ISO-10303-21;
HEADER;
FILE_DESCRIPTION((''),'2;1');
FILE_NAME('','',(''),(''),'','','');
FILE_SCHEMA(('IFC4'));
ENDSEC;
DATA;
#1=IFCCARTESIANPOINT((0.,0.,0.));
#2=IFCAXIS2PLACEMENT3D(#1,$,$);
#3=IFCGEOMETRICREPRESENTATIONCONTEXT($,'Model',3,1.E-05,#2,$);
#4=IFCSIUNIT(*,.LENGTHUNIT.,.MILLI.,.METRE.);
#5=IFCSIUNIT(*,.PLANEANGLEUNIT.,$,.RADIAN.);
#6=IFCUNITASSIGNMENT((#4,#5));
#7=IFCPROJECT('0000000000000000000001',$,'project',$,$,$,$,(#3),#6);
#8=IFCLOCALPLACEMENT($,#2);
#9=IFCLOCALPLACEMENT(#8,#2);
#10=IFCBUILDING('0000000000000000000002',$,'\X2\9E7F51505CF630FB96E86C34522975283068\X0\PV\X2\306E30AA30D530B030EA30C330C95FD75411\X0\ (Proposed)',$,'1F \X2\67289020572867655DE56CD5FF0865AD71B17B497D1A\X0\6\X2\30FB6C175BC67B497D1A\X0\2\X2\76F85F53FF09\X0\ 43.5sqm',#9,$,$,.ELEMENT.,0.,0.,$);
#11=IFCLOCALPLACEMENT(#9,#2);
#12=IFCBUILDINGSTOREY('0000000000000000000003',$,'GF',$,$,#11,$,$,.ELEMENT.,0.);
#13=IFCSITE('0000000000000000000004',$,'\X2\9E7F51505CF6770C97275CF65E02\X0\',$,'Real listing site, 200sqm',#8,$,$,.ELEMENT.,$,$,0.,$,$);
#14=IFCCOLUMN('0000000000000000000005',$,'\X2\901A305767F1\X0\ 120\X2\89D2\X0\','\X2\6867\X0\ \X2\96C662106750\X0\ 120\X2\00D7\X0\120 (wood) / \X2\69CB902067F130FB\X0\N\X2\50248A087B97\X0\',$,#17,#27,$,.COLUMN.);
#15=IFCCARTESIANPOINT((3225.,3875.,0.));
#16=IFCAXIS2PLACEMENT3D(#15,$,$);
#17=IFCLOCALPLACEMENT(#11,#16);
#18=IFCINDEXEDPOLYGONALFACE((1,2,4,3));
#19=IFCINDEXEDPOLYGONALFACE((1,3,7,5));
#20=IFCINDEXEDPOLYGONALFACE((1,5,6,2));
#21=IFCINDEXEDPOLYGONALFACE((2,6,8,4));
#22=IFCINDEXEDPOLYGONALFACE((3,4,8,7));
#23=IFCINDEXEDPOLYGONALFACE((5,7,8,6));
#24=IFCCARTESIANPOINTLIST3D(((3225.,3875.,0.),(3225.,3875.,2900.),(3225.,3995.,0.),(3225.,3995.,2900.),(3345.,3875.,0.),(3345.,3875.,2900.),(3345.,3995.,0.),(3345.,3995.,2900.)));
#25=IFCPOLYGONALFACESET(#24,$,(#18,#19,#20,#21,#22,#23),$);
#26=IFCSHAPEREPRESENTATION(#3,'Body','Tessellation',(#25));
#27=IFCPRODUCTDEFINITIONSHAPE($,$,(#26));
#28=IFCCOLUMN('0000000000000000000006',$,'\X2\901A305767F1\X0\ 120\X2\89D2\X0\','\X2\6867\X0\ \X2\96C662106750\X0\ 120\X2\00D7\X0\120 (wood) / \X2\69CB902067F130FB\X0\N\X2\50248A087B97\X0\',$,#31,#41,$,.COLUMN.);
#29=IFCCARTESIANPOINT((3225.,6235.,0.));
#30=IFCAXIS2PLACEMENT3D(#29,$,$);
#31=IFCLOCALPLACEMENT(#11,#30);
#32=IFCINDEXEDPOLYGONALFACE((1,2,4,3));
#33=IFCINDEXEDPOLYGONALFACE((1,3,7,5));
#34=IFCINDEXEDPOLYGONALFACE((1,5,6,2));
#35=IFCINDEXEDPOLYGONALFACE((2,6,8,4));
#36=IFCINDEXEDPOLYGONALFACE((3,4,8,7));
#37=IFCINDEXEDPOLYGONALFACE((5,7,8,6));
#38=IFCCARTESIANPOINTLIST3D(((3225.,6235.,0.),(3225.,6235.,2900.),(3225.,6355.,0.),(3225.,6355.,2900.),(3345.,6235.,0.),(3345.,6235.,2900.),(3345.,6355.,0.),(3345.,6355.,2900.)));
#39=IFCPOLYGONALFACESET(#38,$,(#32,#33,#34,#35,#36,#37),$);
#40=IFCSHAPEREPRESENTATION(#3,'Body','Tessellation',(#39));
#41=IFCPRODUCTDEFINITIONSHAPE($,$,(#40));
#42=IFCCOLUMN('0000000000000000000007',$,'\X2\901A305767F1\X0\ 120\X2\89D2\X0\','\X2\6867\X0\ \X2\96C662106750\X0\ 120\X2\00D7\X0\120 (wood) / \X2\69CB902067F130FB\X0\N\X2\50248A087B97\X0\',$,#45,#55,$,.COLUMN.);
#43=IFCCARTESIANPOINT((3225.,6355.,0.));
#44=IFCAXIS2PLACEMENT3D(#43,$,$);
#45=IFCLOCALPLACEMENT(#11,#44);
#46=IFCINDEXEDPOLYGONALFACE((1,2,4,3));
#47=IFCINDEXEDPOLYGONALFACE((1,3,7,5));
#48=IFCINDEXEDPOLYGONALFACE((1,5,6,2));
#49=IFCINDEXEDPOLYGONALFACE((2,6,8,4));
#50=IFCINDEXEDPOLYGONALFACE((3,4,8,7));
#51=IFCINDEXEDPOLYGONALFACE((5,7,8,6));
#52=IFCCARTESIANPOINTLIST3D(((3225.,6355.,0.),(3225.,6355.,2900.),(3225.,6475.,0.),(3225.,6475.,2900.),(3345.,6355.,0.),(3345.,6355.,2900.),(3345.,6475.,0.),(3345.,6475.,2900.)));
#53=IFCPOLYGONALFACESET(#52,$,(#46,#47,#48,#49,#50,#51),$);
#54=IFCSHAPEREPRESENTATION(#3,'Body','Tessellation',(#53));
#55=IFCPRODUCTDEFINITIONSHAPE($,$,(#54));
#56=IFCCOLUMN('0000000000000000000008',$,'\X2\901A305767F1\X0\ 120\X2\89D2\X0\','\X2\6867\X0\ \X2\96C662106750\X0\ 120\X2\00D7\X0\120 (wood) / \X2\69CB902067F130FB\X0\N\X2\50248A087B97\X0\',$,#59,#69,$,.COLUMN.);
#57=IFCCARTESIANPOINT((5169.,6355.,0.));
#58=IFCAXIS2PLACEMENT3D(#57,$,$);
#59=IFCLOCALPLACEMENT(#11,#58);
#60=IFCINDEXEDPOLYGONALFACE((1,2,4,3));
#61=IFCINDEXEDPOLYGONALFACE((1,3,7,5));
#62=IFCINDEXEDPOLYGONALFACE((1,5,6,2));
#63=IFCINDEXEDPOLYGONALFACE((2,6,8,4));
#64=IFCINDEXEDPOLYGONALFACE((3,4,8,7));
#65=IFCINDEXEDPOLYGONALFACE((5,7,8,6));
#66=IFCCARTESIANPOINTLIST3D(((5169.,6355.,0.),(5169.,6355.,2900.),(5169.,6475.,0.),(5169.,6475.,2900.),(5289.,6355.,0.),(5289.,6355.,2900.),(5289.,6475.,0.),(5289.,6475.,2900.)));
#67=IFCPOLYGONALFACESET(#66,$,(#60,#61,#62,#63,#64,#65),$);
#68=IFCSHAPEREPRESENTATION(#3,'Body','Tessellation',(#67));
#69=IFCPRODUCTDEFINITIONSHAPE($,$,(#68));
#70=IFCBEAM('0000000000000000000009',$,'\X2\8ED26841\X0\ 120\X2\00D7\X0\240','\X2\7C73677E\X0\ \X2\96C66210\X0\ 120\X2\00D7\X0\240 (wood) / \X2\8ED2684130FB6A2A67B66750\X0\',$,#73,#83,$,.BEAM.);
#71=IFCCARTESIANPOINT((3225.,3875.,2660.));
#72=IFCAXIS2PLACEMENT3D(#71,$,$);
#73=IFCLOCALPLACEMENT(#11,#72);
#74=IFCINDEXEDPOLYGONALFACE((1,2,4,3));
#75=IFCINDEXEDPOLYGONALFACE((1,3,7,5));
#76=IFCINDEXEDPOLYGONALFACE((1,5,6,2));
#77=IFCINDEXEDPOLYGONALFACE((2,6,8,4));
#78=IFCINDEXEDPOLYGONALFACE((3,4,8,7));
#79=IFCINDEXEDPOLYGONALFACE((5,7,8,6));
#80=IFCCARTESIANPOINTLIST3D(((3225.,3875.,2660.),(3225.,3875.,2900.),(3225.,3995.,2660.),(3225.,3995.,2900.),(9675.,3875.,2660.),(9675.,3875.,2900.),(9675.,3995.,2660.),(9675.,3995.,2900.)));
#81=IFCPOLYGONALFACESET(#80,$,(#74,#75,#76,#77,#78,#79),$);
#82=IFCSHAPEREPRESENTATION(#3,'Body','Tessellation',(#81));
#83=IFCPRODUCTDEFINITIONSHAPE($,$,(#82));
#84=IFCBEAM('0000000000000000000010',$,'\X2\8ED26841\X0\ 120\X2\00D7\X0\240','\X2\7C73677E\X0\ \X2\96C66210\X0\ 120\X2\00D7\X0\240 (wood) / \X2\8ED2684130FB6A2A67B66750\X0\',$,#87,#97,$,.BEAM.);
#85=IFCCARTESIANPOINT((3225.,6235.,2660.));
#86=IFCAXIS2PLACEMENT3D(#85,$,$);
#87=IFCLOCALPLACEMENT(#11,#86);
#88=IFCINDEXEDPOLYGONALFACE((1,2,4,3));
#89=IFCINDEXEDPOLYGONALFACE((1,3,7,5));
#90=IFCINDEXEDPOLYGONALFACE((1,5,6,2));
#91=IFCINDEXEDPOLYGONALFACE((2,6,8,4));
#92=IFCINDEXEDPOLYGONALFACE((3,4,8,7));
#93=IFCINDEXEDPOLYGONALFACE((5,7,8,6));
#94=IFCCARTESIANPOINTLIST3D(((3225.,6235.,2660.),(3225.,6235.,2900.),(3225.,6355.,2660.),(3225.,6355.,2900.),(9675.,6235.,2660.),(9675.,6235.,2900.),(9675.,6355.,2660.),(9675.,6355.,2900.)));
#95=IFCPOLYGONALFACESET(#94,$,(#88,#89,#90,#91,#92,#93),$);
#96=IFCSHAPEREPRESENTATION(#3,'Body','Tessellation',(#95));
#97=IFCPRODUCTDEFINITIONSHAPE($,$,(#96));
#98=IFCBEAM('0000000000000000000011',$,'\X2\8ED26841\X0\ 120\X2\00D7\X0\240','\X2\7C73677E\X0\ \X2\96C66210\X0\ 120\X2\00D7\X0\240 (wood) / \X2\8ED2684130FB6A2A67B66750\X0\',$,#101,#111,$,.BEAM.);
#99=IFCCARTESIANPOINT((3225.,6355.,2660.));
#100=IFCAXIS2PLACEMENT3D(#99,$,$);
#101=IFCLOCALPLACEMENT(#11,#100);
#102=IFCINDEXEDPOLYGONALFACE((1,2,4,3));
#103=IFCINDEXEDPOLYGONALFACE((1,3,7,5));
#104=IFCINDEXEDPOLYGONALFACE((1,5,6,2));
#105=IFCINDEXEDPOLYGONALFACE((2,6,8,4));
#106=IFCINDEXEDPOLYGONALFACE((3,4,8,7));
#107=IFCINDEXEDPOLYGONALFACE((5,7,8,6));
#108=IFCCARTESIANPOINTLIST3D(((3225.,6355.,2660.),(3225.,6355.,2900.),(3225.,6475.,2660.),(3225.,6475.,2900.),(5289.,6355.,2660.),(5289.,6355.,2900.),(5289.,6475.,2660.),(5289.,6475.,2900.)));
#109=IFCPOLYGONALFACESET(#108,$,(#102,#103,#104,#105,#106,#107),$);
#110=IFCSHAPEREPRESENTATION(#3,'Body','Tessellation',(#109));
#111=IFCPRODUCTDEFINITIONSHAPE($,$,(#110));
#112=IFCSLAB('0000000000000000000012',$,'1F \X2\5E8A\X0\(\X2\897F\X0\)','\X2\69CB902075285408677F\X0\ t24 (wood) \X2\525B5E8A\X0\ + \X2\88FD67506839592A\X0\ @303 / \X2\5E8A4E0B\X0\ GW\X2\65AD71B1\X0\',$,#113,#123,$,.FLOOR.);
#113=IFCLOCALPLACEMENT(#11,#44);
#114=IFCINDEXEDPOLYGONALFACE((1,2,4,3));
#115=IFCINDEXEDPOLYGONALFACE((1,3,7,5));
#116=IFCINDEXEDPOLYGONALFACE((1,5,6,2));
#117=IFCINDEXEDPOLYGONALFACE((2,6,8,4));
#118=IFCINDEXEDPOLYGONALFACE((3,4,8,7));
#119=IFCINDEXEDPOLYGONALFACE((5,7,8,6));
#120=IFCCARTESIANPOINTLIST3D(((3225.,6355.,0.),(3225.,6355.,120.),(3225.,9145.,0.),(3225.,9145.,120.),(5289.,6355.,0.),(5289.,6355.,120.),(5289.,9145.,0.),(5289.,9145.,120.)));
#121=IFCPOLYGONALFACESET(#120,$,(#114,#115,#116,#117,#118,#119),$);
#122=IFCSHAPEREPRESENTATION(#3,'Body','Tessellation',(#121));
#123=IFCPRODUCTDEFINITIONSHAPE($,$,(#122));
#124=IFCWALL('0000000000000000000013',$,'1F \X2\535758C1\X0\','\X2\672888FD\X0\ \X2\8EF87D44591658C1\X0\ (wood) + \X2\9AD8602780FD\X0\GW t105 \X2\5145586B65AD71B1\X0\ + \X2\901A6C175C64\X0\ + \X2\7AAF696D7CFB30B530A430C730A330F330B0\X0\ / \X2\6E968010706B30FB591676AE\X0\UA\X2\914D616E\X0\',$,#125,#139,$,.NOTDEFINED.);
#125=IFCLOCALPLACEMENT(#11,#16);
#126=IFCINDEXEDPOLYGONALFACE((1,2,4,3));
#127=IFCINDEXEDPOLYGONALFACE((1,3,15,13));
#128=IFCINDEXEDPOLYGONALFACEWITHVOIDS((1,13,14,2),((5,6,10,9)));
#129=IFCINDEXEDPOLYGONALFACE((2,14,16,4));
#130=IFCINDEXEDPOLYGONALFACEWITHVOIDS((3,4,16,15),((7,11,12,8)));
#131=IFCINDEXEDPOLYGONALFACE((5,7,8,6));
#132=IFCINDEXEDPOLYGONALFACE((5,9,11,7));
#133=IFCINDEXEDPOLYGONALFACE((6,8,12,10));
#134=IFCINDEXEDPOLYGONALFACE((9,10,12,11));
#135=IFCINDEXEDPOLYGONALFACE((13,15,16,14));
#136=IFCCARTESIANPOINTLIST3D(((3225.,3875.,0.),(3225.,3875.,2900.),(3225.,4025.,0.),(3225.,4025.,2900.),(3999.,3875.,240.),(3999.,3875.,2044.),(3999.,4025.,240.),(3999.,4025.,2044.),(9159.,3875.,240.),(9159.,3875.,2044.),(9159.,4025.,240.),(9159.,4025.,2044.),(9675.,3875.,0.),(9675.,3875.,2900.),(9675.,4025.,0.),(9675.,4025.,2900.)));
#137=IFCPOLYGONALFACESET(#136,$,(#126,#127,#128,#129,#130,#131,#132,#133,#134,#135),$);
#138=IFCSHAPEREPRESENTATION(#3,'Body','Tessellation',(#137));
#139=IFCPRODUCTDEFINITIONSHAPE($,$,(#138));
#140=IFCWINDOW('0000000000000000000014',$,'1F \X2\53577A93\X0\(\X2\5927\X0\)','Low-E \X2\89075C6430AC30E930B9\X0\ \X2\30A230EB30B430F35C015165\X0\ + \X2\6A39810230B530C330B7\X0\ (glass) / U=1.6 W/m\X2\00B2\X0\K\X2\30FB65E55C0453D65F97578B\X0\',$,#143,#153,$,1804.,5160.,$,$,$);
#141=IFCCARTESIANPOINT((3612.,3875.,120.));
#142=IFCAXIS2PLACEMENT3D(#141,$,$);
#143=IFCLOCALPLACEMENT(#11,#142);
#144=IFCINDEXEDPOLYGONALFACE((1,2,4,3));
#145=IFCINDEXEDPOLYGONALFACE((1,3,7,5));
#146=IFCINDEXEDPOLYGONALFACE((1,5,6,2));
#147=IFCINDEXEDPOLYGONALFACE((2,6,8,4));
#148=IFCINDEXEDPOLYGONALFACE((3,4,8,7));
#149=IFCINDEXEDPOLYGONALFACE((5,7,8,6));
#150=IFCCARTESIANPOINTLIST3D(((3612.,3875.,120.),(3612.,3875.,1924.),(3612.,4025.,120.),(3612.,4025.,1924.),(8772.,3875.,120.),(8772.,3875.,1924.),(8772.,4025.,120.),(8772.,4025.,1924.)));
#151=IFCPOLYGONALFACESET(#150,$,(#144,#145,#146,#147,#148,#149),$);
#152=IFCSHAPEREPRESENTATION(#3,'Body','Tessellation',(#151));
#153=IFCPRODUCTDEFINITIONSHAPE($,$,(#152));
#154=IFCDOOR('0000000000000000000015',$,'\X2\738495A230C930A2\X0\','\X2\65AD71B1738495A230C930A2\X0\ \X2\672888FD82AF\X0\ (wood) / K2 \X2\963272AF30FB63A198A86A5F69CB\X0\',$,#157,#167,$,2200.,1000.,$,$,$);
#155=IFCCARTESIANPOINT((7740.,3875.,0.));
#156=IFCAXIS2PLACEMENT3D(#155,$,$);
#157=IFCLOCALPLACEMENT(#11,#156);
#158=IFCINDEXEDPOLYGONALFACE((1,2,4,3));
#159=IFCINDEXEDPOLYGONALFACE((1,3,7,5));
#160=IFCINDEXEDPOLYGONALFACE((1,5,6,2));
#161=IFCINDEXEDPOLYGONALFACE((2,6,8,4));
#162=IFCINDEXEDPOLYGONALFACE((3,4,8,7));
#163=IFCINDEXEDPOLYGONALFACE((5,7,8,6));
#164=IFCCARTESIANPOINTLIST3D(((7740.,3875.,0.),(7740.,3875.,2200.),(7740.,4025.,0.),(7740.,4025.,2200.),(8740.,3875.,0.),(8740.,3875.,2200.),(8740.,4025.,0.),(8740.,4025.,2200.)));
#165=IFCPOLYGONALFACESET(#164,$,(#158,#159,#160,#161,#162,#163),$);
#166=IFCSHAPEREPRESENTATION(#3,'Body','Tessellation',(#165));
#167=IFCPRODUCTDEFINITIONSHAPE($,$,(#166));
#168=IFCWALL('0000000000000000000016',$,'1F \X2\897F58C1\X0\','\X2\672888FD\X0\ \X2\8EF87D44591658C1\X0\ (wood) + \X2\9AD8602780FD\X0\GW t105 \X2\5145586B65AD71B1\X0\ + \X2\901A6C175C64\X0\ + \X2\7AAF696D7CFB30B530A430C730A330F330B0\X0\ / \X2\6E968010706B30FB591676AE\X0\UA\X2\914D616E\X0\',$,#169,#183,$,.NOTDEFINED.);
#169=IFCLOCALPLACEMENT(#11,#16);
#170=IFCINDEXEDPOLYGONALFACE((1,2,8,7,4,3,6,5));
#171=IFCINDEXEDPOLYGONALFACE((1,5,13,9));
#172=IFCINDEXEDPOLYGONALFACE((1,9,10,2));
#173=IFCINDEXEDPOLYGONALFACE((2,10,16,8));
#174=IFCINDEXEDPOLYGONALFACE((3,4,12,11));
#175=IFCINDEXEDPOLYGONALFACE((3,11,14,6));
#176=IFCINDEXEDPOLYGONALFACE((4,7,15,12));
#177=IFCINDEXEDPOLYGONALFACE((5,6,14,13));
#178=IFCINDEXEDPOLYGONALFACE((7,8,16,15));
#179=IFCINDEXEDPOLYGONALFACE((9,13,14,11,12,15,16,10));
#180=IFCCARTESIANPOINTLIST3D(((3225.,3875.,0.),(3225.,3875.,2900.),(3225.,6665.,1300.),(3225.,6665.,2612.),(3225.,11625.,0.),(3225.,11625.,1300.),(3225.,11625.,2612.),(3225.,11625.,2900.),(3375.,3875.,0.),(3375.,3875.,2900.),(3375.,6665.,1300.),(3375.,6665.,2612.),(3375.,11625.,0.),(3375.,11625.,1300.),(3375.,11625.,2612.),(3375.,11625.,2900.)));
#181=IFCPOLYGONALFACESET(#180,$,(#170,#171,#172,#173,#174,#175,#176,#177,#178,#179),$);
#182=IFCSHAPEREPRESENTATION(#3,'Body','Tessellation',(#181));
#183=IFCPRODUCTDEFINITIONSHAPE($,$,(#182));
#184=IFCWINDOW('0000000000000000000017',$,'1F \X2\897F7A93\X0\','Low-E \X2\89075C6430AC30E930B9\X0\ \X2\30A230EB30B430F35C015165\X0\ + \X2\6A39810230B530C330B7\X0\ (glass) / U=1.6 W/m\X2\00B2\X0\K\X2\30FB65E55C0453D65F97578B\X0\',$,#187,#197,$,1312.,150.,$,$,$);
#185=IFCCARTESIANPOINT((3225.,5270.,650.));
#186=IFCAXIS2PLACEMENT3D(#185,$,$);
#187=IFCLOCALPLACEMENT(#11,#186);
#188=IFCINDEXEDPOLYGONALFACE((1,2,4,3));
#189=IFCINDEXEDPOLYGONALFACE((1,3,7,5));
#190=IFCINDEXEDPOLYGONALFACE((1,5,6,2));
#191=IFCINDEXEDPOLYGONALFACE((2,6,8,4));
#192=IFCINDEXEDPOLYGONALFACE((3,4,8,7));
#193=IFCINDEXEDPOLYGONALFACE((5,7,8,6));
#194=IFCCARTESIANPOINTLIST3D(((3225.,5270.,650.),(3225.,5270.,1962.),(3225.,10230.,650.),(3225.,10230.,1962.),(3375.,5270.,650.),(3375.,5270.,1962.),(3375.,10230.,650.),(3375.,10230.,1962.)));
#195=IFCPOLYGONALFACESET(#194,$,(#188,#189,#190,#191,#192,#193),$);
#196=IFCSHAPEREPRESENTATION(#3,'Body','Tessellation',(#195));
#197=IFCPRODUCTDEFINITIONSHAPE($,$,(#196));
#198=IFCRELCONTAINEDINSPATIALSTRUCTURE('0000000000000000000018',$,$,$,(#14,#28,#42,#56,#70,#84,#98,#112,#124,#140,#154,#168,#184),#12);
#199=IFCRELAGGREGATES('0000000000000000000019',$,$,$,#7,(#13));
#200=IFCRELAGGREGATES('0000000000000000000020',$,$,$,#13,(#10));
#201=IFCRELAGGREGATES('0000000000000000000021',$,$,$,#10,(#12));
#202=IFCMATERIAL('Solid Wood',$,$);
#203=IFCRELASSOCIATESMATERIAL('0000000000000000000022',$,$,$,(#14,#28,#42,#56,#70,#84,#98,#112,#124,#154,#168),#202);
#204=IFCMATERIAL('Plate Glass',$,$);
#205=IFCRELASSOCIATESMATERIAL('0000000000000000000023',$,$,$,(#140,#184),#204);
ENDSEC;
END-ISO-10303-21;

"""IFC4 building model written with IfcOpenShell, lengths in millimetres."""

from ifc_helpers import new_model, si_unit, frame, frame_2d, origin, place, context, project, spatial, rectangle, extrude, material, element, fill, save


model = new_model("IFC4")

# Units and contexts
model_context = context("Model", 3, precision=1e-05, world=origin())
ifc_project = project(units=[si_unit("LENGTHUNIT", "METRE", prefix="MILLI"), si_unit("PLANEANGLEUNIT", "RADIAN")], contexts=[model_context])

# Site, building, storey
site_placement = place(None, origin())
site = spatial("IfcSite", under=ifc_project, at=site_placement, Name="鹿児島県霧島市", ObjectType="Real listing site, 200sqm", CompositionType="ELEMENT", RefElevation=0.0)
building_placement = place(site_placement, origin())
building = spatial("IfcBuilding", under=site, at=building_placement, Name="鹿児島・雨水利用とPVのオフグリッド志向 (Proposed)", ObjectType="1F 木造在来工法（断熱等級6・気密等級2相当） 43.5sqm", CompositionType="ELEMENT", ElevationOfRefHeight=0.0, ElevationOfTerrain=0.0)
storey_placement = place(building_placement, origin())
storey = spatial("IfcBuildingStorey", under=building, at=storey_placement, Name="GF", CompositionType="ELEMENT", Elevation=0.0)

# Columns
ifc_material_1 = material(Name="Solid Wood")
column_1_placement = place(storey_placement, frame((3225.0, 3875.0, 0.0)))
element("IfcColumn", 1, at=column_1_placement, inside=storey, material=ifc_material_1, Name="通し柱 120角", Description="桧 集成材 120×120 (wood) / 構造柱・N値計算", PredefinedType="COLUMN", context=model_context, shape_type="SweptSolid", body=[
    extrude(rectangle(XDim=120.0, YDim=120.0, at=frame_2d((60.0, 60.0))), frame((3225.0, 3875.0, 0.0)), (0.0, 0.0, 1.0), 2900.0),
])
column_2_placement = place(storey_placement, frame((3225.0, 6235.0, 0.0)))
element("IfcColumn", 2, at=column_2_placement, inside=storey, material=ifc_material_1, Name="通し柱 120角", Description="桧 集成材 120×120 (wood) / 構造柱・N値計算", PredefinedType="COLUMN", context=model_context, shape_type="SweptSolid", body=[
    extrude(rectangle(XDim=120.0, YDim=120.0, at=frame_2d((60.0, 60.0))), frame((3225.0, 6235.0, 0.0)), (0.0, 0.0, 1.0), 2900.0),
])
column_3_placement = place(storey_placement, frame((3225.0, 6355.0, 0.0)))
element("IfcColumn", 3, at=column_3_placement, inside=storey, material=ifc_material_1, Name="通し柱 120角", Description="桧 集成材 120×120 (wood) / 構造柱・N値計算", PredefinedType="COLUMN", context=model_context, shape_type="SweptSolid", body=[
    extrude(rectangle(XDim=120.0, YDim=120.0, at=frame_2d((60.0, 60.0))), frame((3225.0, 6355.0, 0.0)), (0.0, 0.0, 1.0), 2900.0),
])
column_4_placement = place(storey_placement, frame((5169.0, 6355.0, 0.0)))
element("IfcColumn", 4, at=column_4_placement, inside=storey, material=ifc_material_1, Name="通し柱 120角", Description="桧 集成材 120×120 (wood) / 構造柱・N値計算", PredefinedType="COLUMN", context=model_context, shape_type="SweptSolid", body=[
    extrude(rectangle(XDim=120.0, YDim=120.0, at=frame_2d((60.0, 60.0))), frame((5169.0, 6355.0, 0.0)), (0.0, 0.0, 1.0), 2900.0),
])

# Beams
beam_1_placement = place(storey_placement, frame((3225.0, 3875.0, 2660.0)))
element("IfcBeam", 5, at=beam_1_placement, inside=storey, material=ifc_material_1, Name="軒桁 120×240", Description="米松 集成 120×240 (wood) / 軒桁・横架材", PredefinedType="BEAM", context=model_context, shape_type="SweptSolid", body=[
    extrude(rectangle(XDim=6450.0, YDim=120.0, at=frame_2d((3225.0, 60.0))), frame((3225.0, 3875.0, 2660.0)), (0.0, 0.0, 1.0), 240.0),
])
beam_2_placement = place(storey_placement, frame((3225.0, 6235.0, 2660.0)))
element("IfcBeam", 6, at=beam_2_placement, inside=storey, material=ifc_material_1, Name="軒桁 120×240", Description="米松 集成 120×240 (wood) / 軒桁・横架材", PredefinedType="BEAM", context=model_context, shape_type="SweptSolid", body=[
    extrude(rectangle(XDim=6450.0, YDim=120.0, at=frame_2d((3225.0, 60.0))), frame((3225.0, 6235.0, 2660.0)), (0.0, 0.0, 1.0), 240.0),
])
beam_3_placement = place(storey_placement, frame((3225.0, 6355.0, 2660.0)))
element("IfcBeam", 7, at=beam_3_placement, inside=storey, material=ifc_material_1, Name="軒桁 120×240", Description="米松 集成 120×240 (wood) / 軒桁・横架材", PredefinedType="BEAM", context=model_context, shape_type="SweptSolid", body=[
    extrude(rectangle(XDim=2064.0, YDim=120.0, at=frame_2d((1032.0, 60.0))), frame((3225.0, 6355.0, 2660.0)), (0.0, 0.0, 1.0), 240.0),
])

# Slab
slab_1_placement = place(storey_placement, frame((3225.0, 6355.0, 0.0)))
element("IfcSlab", 8, at=slab_1_placement, inside=storey, material=ifc_material_1, Name="1F 床(西)", Description="構造用合板 t24 (wood) 剛床 + 製材根太 @303 / 床下 GW断熱", PredefinedType="FLOOR", context=model_context, shape_type="SweptSolid", body=[
    extrude(rectangle(XDim=2064.0, YDim=2790.0, at=frame_2d((1032.0, 1395.0))), frame((3225.0, 6355.0, 0.0)), (0.0, 0.0, 1.0), 120.0),
])

# Wall, openings, window, door
wall_1_placement = place(storey_placement, frame((3225.0, 3875.0, 0.0)))
wall_1 = element("IfcWall", 9, at=wall_1_placement, inside=storey, material=ifc_material_1, Name="1F 南壁", Description="木製 軸組外壁 (wood) + 高性能GW t105 充填断熱 + 通気層 + 窯業系サイディング / 準耐火・外皮UA配慮", PredefinedType="NOTDEFINED", context=model_context, shape_type="SweptSolid", body=[
    extrude(rectangle(XDim=6450.0, YDim=150.0, at=frame_2d((3225.0, 75.0))), frame((3225.0, 3875.0, 0.0)), (0.0, 0.0, 1.0), 2900.0),
])
opening_1_placement = place(storey_placement, frame((3612.0, 3875.0, 120.0)))
opening_1 = element("IfcOpeningElement", 10, at=opening_1_placement, cuts=wall_1, PredefinedType="NOTDEFINED", context=model_context, shape_type="SweptSolid", body=[
    extrude(rectangle(XDim=5160.0, YDim=150.0, at=frame_2d((2580.0, 75.0))), frame((3612.0, 3875.0, 120.0)), (0.0, 0.0, 1.0), 1804.0),
])
opening_2_placement = place(storey_placement, frame((7740.0, 3875.0, 0.0)))
opening_2 = element("IfcOpeningElement", 11, at=opening_2_placement, cuts=wall_1, PredefinedType="NOTDEFINED", context=model_context, shape_type="SweptSolid", body=[
    extrude(rectangle(XDim=1000.0, YDim=150.0, at=frame_2d((500.0, 75.0))), frame((7740.0, 3875.0, 0.0)), (0.0, 0.0, 1.0), 2200.0),
])
ifc_material_2 = material(Name="Plate Glass")
window_1_placement = place(storey_placement, frame((3612.0, 3875.0, 120.0)))
window_1 = element("IfcWindow", 12, at=window_1_placement, inside=storey, material=ifc_material_2, Name="1F 南窓(大)", Description="Low-E 複層ガラス アルゴン封入 + 樹脂サッシ (glass) / U=1.6 W/m²K・日射取得型", OverallHeight=1804.0, OverallWidth=5160.0, context=model_context, shape_type="SweptSolid", body=[
    extrude(rectangle(XDim=5160.0, YDim=150.0, at=frame_2d((2580.0, 75.0))), frame((3612.0, 3875.0, 120.0)), (0.0, 0.0, 1.0), 1804.0),
])
fill(opening_1, window_1)
door_placement = place(storey_placement, frame((7740.0, 3875.0, 0.0)))
door = element("IfcDoor", 13, at=door_placement, inside=storey, material=ifc_material_1, Name="玄関ドア", Description="断熱玄関ドア 木製芯 (wood) / K2 防犯・採風機構", OverallHeight=2200.0, OverallWidth=1000.0, context=model_context, shape_type="SweptSolid", body=[
    extrude(rectangle(XDim=1000.0, YDim=150.0, at=frame_2d((500.0, 75.0))), frame((7740.0, 3875.0, 0.0)), (0.0, 0.0, 1.0), 2200.0),
])
fill(opening_2, door)

# Wall, opening, window
wall_2_placement = place(storey_placement, frame((3225.0, 3875.0, 0.0)))
wall_2 = element("IfcWall", 14, at=wall_2_placement, inside=storey, material=ifc_material_1, Name="1F 西壁", Description="木製 軸組外壁 (wood) + 高性能GW t105 充填断熱 + 通気層 + 窯業系サイディング / 準耐火・外皮UA配慮", PredefinedType="NOTDEFINED", context=model_context, shape_type="SweptSolid", body=[
    extrude(rectangle(XDim=150.0, YDim=7750.0, at=frame_2d((75.0, 3875.0))), frame((3225.0, 3875.0, 0.0)), (0.0, 0.0, 1.0), 2900.0),
])
opening_3_placement = place(storey_placement, frame((3225.0, 5270.0, 650.0)))
opening_3 = element("IfcOpeningElement", 15, at=opening_3_placement, cuts=wall_2, PredefinedType="NOTDEFINED", context=model_context, shape_type="SweptSolid", body=[
    extrude(rectangle(XDim=150.0, YDim=4960.0, at=frame_2d((75.0, 2480.0))), frame((3225.0, 5270.0, 650.0)), (0.0, 0.0, 1.0), 1312.0),
])
window_2_placement = place(storey_placement, frame((3225.0, 5270.0, 650.0)))
window_2 = element("IfcWindow", 16, at=window_2_placement, inside=storey, material=ifc_material_2, Name="1F 西窓", Description="Low-E 複層ガラス アルゴン封入 + 樹脂サッシ (glass) / U=1.6 W/m²K・日射取得型", OverallHeight=1312.0, OverallWidth=150.0, context=model_context, shape_type="SweptSolid", body=[
    extrude(rectangle(XDim=150.0, YDim=4960.0, at=frame_2d((75.0, 2480.0))), frame((3225.0, 5270.0, 650.0)), (0.0, 0.0, 1.0), 1312.0),
])
fill(opening_3, window_2)

save(model, "model.ifc")
